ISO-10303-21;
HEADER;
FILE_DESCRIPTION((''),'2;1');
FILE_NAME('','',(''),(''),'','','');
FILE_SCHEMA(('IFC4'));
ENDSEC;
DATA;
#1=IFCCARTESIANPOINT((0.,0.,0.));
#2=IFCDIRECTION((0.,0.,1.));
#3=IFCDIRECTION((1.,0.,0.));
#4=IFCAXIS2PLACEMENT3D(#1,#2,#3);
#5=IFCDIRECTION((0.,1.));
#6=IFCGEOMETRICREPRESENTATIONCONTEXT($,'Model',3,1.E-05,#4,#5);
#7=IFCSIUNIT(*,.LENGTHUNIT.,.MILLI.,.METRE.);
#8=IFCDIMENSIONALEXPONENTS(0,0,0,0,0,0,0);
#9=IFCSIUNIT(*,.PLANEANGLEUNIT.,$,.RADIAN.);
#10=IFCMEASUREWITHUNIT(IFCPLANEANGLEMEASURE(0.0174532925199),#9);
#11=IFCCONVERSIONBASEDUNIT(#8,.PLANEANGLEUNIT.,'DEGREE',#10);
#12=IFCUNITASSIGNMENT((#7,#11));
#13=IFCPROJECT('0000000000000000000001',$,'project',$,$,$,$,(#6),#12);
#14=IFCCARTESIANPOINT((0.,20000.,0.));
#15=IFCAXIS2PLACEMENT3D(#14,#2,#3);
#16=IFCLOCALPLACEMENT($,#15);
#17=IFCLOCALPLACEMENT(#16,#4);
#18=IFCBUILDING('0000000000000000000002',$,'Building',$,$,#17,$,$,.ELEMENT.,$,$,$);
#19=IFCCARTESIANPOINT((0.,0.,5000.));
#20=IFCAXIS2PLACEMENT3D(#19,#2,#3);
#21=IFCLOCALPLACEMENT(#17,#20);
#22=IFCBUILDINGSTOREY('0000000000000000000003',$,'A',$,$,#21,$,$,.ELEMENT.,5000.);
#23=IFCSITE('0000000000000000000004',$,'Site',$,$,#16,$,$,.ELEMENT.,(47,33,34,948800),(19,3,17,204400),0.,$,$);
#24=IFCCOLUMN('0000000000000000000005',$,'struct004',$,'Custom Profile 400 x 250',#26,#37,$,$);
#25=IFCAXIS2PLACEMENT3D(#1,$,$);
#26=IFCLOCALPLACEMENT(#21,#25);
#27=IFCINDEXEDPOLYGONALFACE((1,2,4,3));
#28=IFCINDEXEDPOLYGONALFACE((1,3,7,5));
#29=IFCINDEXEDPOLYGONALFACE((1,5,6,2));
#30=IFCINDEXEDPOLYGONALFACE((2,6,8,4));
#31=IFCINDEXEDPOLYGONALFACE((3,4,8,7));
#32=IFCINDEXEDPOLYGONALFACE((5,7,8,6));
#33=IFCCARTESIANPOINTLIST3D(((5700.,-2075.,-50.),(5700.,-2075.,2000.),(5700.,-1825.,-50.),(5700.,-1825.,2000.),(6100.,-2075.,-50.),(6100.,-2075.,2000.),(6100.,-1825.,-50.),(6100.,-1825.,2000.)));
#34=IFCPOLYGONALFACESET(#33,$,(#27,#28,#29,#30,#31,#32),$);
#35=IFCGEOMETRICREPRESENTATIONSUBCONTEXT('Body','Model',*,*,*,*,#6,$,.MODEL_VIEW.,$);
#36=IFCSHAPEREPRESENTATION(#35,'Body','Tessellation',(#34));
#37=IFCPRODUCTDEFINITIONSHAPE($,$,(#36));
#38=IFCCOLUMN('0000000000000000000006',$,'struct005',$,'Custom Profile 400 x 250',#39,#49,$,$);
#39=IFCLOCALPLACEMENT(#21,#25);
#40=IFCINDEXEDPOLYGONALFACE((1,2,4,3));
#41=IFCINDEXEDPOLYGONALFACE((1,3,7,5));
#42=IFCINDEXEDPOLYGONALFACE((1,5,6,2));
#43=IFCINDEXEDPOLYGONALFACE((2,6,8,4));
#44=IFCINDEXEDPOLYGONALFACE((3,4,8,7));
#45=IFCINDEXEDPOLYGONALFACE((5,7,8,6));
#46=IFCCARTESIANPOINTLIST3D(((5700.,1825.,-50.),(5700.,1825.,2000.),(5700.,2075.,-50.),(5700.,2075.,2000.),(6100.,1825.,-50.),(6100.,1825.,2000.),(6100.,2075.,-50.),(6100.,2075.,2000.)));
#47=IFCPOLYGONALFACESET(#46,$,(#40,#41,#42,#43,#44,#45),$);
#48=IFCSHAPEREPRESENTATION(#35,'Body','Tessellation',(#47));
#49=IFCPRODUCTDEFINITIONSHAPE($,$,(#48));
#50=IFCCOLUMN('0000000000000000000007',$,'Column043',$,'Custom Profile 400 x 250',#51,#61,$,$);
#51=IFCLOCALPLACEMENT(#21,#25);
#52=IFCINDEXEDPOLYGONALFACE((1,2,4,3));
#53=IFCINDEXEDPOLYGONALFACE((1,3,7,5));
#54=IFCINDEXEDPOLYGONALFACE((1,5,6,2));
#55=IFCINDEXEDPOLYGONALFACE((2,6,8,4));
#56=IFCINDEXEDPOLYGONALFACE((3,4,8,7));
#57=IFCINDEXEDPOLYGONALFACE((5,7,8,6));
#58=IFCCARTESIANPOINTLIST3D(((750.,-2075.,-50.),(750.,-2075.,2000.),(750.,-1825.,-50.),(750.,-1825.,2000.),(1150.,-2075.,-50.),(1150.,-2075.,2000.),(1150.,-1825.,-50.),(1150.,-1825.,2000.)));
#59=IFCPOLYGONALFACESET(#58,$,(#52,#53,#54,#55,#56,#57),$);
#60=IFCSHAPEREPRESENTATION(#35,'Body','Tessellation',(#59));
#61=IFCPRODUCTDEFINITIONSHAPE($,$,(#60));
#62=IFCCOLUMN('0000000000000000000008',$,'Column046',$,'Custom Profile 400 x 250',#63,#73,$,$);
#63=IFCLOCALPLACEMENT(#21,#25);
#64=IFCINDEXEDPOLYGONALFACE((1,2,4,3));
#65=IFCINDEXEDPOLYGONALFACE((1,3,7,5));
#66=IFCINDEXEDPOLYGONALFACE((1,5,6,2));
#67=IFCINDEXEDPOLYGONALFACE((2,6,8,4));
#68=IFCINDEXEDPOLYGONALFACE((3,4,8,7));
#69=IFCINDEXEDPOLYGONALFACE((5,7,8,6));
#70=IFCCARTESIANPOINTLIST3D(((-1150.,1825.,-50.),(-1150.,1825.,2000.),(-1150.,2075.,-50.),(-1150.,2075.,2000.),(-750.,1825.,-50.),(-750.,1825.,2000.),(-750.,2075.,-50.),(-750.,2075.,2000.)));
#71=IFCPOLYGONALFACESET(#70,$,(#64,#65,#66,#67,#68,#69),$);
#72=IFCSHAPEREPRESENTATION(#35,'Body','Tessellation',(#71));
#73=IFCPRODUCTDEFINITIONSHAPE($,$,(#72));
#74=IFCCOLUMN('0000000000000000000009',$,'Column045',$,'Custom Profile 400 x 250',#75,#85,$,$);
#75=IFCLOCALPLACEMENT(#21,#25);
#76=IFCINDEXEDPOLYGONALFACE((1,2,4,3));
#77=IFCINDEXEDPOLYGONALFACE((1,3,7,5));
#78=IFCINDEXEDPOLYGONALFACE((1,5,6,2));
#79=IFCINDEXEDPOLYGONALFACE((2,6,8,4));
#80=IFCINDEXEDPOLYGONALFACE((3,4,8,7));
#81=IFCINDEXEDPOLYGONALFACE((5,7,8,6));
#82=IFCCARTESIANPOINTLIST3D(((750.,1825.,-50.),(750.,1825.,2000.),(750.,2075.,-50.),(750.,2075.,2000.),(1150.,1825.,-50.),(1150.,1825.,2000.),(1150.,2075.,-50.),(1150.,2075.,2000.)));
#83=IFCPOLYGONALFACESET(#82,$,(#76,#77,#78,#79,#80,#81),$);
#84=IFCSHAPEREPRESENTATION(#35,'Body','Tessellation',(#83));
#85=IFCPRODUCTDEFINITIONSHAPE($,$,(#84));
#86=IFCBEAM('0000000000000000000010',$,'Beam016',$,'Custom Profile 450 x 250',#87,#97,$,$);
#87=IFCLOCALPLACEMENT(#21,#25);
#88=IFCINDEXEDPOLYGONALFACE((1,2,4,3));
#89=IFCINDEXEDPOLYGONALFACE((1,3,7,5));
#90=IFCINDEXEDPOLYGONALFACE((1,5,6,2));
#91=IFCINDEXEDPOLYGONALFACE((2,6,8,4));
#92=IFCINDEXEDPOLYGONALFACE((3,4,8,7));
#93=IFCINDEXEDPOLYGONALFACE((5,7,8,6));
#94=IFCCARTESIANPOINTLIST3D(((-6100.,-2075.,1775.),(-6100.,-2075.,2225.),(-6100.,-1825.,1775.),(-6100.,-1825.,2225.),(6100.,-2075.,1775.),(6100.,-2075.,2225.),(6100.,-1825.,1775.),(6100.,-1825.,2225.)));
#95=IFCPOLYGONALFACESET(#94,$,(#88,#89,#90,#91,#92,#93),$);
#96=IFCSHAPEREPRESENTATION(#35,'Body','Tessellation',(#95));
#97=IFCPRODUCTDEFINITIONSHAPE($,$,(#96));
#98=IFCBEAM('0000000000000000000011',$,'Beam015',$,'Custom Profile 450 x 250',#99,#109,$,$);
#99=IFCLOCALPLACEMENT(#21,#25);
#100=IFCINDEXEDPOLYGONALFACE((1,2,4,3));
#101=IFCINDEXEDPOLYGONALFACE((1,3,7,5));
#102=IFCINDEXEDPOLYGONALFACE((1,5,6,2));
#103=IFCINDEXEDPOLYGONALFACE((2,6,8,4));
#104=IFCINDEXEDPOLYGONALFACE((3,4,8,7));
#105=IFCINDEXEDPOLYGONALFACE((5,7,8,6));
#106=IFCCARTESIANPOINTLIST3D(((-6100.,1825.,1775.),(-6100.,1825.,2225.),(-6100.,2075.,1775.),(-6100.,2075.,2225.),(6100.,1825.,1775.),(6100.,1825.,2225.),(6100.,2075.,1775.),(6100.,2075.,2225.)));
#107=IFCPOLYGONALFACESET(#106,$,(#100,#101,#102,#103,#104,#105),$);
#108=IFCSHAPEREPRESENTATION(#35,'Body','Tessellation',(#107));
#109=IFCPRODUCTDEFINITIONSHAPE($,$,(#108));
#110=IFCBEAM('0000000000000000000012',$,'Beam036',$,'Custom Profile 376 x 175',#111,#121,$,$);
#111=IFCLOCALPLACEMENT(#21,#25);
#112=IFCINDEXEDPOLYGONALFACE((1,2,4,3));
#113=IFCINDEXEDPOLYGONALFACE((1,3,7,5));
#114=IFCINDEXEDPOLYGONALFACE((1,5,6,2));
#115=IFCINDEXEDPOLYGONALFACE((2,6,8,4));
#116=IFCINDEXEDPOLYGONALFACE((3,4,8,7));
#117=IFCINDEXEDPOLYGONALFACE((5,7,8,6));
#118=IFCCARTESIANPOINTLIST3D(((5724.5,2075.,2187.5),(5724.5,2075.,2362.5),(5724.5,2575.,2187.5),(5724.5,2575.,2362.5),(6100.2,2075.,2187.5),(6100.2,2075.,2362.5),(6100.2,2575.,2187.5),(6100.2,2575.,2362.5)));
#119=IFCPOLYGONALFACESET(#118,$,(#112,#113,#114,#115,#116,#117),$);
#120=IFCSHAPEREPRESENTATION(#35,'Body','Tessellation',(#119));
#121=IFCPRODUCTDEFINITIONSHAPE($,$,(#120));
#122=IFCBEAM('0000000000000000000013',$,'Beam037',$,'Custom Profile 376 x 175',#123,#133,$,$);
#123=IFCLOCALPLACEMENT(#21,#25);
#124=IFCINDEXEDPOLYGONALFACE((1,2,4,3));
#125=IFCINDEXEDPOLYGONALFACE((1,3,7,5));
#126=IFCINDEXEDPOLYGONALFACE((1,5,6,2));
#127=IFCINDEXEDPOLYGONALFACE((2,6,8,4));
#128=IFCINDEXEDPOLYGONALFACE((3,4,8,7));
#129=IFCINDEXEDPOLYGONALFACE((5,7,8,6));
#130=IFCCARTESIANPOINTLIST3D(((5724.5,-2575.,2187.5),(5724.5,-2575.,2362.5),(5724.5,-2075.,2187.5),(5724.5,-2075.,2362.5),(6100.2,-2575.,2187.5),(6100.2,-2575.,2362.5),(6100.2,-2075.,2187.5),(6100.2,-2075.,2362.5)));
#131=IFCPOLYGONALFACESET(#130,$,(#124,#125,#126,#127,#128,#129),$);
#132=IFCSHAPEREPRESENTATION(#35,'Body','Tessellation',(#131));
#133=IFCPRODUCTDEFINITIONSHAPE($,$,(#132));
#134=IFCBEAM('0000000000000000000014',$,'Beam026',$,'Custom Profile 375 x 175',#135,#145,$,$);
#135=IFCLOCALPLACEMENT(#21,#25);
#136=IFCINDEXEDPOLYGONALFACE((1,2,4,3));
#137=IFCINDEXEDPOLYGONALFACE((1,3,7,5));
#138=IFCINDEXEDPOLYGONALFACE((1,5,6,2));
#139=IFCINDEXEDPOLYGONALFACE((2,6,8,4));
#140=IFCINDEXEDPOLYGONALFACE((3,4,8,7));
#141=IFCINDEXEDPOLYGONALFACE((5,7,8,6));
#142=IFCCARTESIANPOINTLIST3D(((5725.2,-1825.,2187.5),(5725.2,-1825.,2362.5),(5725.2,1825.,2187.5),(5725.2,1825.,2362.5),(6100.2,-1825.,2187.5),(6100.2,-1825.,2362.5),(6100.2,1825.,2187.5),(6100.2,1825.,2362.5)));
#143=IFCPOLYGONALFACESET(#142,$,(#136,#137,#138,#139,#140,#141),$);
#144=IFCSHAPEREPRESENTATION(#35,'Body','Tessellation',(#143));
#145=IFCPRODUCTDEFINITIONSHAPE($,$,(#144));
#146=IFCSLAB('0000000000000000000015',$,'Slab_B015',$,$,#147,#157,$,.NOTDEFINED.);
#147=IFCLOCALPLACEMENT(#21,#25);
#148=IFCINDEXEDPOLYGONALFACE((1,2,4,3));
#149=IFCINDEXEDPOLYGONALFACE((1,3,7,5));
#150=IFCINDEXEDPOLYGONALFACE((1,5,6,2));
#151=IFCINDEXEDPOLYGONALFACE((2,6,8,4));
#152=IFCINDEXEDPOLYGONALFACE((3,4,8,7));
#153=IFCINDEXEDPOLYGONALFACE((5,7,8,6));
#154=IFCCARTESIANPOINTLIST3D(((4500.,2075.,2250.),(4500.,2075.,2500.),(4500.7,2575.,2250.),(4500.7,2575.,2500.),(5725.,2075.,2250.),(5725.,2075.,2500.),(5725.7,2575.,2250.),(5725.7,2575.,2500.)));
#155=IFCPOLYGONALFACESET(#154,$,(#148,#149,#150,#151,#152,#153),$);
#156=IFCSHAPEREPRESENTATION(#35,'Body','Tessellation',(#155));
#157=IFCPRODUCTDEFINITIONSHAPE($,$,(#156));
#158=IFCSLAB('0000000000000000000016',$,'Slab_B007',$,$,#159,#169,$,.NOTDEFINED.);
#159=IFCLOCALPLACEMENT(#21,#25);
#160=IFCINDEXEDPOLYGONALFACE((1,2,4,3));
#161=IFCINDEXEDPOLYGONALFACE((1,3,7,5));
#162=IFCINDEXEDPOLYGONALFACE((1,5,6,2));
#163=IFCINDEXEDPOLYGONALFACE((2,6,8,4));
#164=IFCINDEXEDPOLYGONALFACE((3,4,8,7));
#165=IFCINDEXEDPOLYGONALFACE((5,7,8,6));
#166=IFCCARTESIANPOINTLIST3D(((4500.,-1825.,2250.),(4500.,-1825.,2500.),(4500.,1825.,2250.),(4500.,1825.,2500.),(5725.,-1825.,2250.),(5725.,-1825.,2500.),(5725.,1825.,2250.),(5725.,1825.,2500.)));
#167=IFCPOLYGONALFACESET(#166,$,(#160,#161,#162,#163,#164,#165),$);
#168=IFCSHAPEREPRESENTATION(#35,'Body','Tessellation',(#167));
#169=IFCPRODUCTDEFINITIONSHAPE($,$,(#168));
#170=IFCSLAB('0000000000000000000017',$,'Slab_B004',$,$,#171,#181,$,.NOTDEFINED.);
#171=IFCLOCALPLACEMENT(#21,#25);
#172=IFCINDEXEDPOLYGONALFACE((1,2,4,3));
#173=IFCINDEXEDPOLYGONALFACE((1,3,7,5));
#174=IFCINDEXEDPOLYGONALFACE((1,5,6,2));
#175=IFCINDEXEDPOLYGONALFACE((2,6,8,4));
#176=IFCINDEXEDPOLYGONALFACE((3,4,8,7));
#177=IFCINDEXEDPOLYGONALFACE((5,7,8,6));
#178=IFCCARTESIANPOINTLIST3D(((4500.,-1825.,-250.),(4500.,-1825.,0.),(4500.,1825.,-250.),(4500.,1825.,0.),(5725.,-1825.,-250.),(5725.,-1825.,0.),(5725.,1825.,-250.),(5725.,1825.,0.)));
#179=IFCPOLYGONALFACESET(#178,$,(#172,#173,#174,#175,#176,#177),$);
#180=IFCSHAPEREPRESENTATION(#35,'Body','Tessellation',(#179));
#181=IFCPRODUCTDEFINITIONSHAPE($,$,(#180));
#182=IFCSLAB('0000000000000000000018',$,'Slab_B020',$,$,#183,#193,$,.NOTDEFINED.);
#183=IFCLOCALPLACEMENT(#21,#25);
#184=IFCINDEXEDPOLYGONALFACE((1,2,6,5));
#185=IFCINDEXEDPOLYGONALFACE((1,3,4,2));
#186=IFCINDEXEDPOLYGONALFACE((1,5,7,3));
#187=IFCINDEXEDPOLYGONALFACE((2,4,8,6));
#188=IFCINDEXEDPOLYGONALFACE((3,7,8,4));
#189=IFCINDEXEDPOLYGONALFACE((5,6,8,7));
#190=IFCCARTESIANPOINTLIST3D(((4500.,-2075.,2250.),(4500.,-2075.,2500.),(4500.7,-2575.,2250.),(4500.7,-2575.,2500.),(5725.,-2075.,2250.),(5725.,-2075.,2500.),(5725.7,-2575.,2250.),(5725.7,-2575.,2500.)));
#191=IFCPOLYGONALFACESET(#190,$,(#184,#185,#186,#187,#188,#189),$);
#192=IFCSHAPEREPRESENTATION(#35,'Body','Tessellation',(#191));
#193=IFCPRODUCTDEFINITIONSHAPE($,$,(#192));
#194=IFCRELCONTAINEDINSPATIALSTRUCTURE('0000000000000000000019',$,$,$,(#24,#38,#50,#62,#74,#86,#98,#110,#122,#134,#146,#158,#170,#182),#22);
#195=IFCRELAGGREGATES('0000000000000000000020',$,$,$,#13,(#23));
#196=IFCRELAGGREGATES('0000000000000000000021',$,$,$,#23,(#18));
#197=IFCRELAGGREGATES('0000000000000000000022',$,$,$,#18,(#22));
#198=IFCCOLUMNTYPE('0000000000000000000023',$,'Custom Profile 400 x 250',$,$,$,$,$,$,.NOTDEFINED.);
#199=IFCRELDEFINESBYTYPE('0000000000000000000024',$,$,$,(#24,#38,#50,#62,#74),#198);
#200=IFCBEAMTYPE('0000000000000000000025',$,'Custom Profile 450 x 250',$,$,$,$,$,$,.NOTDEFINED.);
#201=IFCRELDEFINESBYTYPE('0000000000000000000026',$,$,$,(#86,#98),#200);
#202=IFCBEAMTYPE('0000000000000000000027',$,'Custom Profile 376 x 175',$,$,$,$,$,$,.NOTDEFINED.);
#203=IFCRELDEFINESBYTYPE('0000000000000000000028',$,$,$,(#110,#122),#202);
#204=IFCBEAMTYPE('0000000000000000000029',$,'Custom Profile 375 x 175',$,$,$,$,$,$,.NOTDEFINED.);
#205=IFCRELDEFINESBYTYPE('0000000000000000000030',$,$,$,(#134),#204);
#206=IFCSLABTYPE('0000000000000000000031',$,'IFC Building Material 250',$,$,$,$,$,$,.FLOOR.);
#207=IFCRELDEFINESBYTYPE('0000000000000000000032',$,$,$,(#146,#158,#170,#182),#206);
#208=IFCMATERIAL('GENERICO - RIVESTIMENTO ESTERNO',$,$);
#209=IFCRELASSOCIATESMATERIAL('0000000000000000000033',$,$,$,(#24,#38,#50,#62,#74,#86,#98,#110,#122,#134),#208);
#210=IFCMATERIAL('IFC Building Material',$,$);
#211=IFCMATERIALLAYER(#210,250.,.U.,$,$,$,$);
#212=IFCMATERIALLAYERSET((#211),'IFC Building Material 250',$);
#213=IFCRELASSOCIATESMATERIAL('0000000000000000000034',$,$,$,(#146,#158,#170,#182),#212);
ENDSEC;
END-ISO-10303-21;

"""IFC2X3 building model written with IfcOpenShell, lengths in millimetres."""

from ifc_helpers import new_model, entity, si_unit, converted_unit, direction, frame, frame_2d, origin_with_axes, origin_2d_with_axis, place, context, subcontext, project, spatial, polyline, rectangle, outline, extrude, material, layer, layer_set, layer_usage, type_object, element, save


model = new_model("IFC2X3")

# Units and contexts
model_context = context("Model", 3, precision=1e-05, world=origin_with_axes(), true_north=direction((0.0, 1.0)))
body_context = subcontext(model_context, "Body", "Model", "MODEL_VIEW")
ifc_project = project(units=[si_unit("LENGTHUNIT", "METRE", prefix="MILLI"), converted_unit("PLANEANGLEUNIT", "DEGREE", entity("IfcPlaneAngleMeasure", 0.0174532925199), si_unit("PLANEANGLEUNIT", "RADIAN"), dimensions=[0, 0, 0, 0, 0, 0, 0])], contexts=[model_context])

# Site, building, storey
site_placement = place(None, frame((0.0, 20000.0, 0.0), z_axis=(0.0, 0.0, 1.0), x_axis=(1.0, 0.0, 0.0)))
site = spatial("IfcSite", under=ifc_project, at=site_placement, Name="Site", CompositionType="ELEMENT", RefLatitude=(47, 33, 34, 948800), RefLongitude=(19, 3, 17, 204400), RefElevation=0.0)
building_placement = place(site_placement, origin_with_axes())
building = spatial("IfcBuilding", under=site, at=building_placement, Name="Building", CompositionType="ELEMENT")
storey_placement = place(building_placement, frame((0.0, 0.0, 5000.0), z_axis=(0.0, 0.0, 1.0), x_axis=(1.0, 0.0, 0.0)))
storey = spatial("IfcBuildingStorey", under=building, at=storey_placement, Name="A", CompositionType="ELEMENT", Elevation=5000.0)

# Columns
ifc_material_1 = material(Name="GENERICO - RIVESTIMENTO ESTERNO")
column_type = type_object("IfcColumnType", Name="Custom Profile 400 x 250", PredefinedType="NOTDEFINED")
for number, where, z_axis, x_axis, name in (
    (1, (5900.0, -1950.0, -50.0), (0.0, 0.0, 1.0), (1.0, 0.0, 0.0), "struct004"),
    (2, (5900.0, 1950.0, -50.0), (0.0, 0.0, 1.0), (1.0, 0.0, 0.0), "struct005"),
    (3, (950.0, -1950.0, -50.0), (0.0, 0.0, 1.0), (1.0, 0.0, 0.0), "Column043"),
    (4, (-950.0, 1950.0, -50.0), (0.0, 0.0, 1.0), (1.0, 0.0, 0.0), "Column046"),
    (5, (950.0, 1950.0, -50.0), (0.0, 0.0, 1.0), (1.0, 0.0, 0.0), "Column045"),
):
    element("IfcColumn", number, at=place(storey_placement, frame(where, z_axis=z_axis, x_axis=x_axis)), inside=storey, type_object=column_type, material=ifc_material_1, Name=name, ObjectType="Custom Profile 400 x 250", context=body_context, shape_type="SweptSolid", body=[
        extrude(rectangle(XDim=400.0, YDim=250.0, at=origin_2d_with_axis()), origin_with_axes(), (0.0, 0.0, 1.0), 2050.0),
    ])

# Beams
beam_type_1 = type_object("IfcBeamType", Name="Custom Profile 450 x 250", PredefinedType="NOTDEFINED")
for number, where, z_axis, x_axis, name in (
    (6, (6100.0, -1950.0, 2225.0), (0.0, 0.0, 1.0), (0.0, 1.0, 0.0), "Beam016"),
    (7, (6100.0, 1950.0, 2225.0), (0.0, 0.0, 1.0), (0.0, 1.0, 0.0), "Beam015"),
):
    element("IfcBeam", number, at=place(storey_placement, frame(where, z_axis=z_axis, x_axis=x_axis)), inside=storey, type_object=beam_type_1, material=ifc_material_1, Name=name, ObjectType="Custom Profile 450 x 250", context=body_context, shape_type="SweptSolid", body=[
        extrude(rectangle(XDim=450.0, YDim=250.0, at=frame_2d((-225.0, 0.0), x_axis=(1.0, 0.0))), frame((0.0, 0.0, 0.0), z_axis=(0.0, 1.0, 0.0), x_axis=(0.0, 0.0, 1.0)), (0.0, 0.0, 1.0), 12200.0),
    ])
beam_type_2 = type_object("IfcBeamType", Name="Custom Profile 376 x 175", PredefinedType="NOTDEFINED")
for number, where, z_axis, x_axis, name in (
    (8, (5912.3, 2575.0, 2362.5), (0.0, 0.0, 1.0), (-1.0, 0.0, 0.0), "Beam036"),
    (9, (5912.3, -2075.0, 2362.5), (0.0, 0.0, 1.0), (-1.0, 0.0, 0.0), "Beam037"),
):
    element("IfcBeam", number, at=place(storey_placement, frame(where, z_axis=z_axis, x_axis=x_axis)), inside=storey, type_object=beam_type_2, material=ifc_material_1, Name=name, ObjectType="Custom Profile 376 x 175", context=body_context, shape_type="SweptSolid", body=[
        extrude(rectangle(XDim=175.0, YDim=375.7, at=frame_2d((-87.5, 0.0), x_axis=(1.0, 0.0))), frame((0.0, 0.0, 0.0), z_axis=(0.0, 1.0, 0.0), x_axis=(0.0, 0.0, 1.0)), (0.0, 0.0, 1.0), 500.0),
    ])
beam_type_3 = type_object("IfcBeamType", Name="Custom Profile 375 x 175", PredefinedType="NOTDEFINED")
beam_placement = place(storey_placement, frame((5912.7, -1825.0, 2362.5), z_axis=(0.0, 0.0, 1.0), x_axis=(1.0, 0.0, 0.0)))
element("IfcBeam", 10, at=beam_placement, inside=storey, type_object=beam_type_3, material=ifc_material_1, Name="Beam026", ObjectType="Custom Profile 375 x 175", context=body_context, shape_type="SweptSolid", body=[
    extrude(rectangle(XDim=175.0, YDim=375.0, at=frame_2d((-87.5, 0.0), x_axis=(1.0, 0.0))), frame((0.0, 0.0, 0.0), z_axis=(0.0, 1.0, 0.0), x_axis=(0.0, 0.0, 1.0)), (0.0, 0.0, 1.0), 3650.0),
])

# Slabs
ifc_material_2 = material(Name="IFC Building Material")
ifc_layer_1 = layer(ifc_material_2, 250.0, ventilated="UNKNOWN")
ifc_layer_set_1 = layer_set([ifc_layer_1], Name="IFC Building Material 250")
ifc_layer_usage_1 = layer_usage(ifc_layer_set_1, "AXIS3", "NEGATIVE", 250.0)
slab_type_1 = type_object("IfcSlabType", Name="IFC Building Material 250", PredefinedType="FLOOR")
slab_1_placement = place(storey_placement, frame((4500.7, 2575.0, 2500.0), z_axis=(0.0, 0.0, 1.0), x_axis=(1.0, 0.0, 0.0)))
element("IfcSlab", 11, at=slab_1_placement, inside=storey, type_object=slab_type_1, material=ifc_layer_usage_1, Name="Slab_B015", PredefinedType="NOTDEFINED", context=body_context, shape_type="SweptSolid", body=[
    extrude(outline(polyline([(0.0, 0.0), (-0.7, -500.0), (1224.3, -500.0), (1225.0, 0.0), (0.0, 0.0)])), frame((0.0, 0.0, -250.0), z_axis=(0.0, 0.0, 1.0), x_axis=(1.0, 0.0, 0.0)), (0.0, 0.0, 1.0), 250.0),
])
ifc_layer_usage_2 = layer_usage(ifc_layer_set_1, "AXIS3", "NEGATIVE", 250.0)
slab_2_placement = place(storey_placement, frame((5725.0, 1825.0, 2500.0), z_axis=(0.0, 0.0, 1.0), x_axis=(1.0, 0.0, 0.0)))
element("IfcSlab", 12, at=slab_2_placement, inside=storey, type_object=slab_type_1, material=ifc_layer_usage_2, Name="Slab_B007", PredefinedType="NOTDEFINED", context=body_context, shape_type="SweptSolid", body=[
    extrude(outline(polyline([(0.0, 0.0), (-1225.0, 0.0), (-1225.0, -3650.0), (0.0, -3650.0), (0.0, 0.0)])), frame((0.0, 0.0, -250.0), z_axis=(0.0, 0.0, 1.0), x_axis=(1.0, 0.0, 0.0)), (0.0, 0.0, 1.0), 250.0),
])
ifc_layer_usage_3 = layer_usage(ifc_layer_set_1, "AXIS3", "NEGATIVE", 250.0)
slab_3_placement = place(storey_placement, frame((5725.0, 1825.0, 0.0), z_axis=(0.0, 0.0, 1.0), x_axis=(1.0, 0.0, 0.0)))
element("IfcSlab", 13, at=slab_3_placement, inside=storey, type_object=slab_type_1, material=ifc_layer_usage_3, Name="Slab_B004", PredefinedType="NOTDEFINED", context=body_context, shape_type="SweptSolid", body=[
    extrude(outline(polyline([(0.0, 0.0), (-1225.0, 0.0), (-1225.0, -3650.0), (0.0, -3650.0), (0.0, 0.0)])), frame((0.0, 0.0, -250.0), z_axis=(0.0, 0.0, 1.0), x_axis=(1.0, 0.0, 0.0)), (0.0, 0.0, 1.0), 250.0),
])
ifc_layer_usage_4 = layer_usage(ifc_layer_set_1, "AXIS3", "NEGATIVE", 250.0)
slab_4_placement = place(storey_placement, frame((5725.0, -2075.0, 2500.0), z_axis=(0.0, 0.0, 1.0), x_axis=(1.0, 0.0, 0.0)))
element("IfcSlab", 14, at=slab_4_placement, inside=storey, type_object=slab_type_1, material=ifc_layer_usage_4, Name="Slab_B020", PredefinedType="NOTDEFINED", context=body_context, shape_type="SweptSolid", body=[
    extrude(outline(polyline([(0.0, 0.0), (-1225.0, 0.0), (-1224.3, -500.0), (0.7, -500.0), (0.0, 0.0)])), frame((0.0, 0.0, -250.0), z_axis=(0.0, 0.0, 1.0), x_axis=(1.0, 0.0, 0.0)), (0.0, 0.0, 1.0), 250.0),
])

save(model, "model.ifc")
